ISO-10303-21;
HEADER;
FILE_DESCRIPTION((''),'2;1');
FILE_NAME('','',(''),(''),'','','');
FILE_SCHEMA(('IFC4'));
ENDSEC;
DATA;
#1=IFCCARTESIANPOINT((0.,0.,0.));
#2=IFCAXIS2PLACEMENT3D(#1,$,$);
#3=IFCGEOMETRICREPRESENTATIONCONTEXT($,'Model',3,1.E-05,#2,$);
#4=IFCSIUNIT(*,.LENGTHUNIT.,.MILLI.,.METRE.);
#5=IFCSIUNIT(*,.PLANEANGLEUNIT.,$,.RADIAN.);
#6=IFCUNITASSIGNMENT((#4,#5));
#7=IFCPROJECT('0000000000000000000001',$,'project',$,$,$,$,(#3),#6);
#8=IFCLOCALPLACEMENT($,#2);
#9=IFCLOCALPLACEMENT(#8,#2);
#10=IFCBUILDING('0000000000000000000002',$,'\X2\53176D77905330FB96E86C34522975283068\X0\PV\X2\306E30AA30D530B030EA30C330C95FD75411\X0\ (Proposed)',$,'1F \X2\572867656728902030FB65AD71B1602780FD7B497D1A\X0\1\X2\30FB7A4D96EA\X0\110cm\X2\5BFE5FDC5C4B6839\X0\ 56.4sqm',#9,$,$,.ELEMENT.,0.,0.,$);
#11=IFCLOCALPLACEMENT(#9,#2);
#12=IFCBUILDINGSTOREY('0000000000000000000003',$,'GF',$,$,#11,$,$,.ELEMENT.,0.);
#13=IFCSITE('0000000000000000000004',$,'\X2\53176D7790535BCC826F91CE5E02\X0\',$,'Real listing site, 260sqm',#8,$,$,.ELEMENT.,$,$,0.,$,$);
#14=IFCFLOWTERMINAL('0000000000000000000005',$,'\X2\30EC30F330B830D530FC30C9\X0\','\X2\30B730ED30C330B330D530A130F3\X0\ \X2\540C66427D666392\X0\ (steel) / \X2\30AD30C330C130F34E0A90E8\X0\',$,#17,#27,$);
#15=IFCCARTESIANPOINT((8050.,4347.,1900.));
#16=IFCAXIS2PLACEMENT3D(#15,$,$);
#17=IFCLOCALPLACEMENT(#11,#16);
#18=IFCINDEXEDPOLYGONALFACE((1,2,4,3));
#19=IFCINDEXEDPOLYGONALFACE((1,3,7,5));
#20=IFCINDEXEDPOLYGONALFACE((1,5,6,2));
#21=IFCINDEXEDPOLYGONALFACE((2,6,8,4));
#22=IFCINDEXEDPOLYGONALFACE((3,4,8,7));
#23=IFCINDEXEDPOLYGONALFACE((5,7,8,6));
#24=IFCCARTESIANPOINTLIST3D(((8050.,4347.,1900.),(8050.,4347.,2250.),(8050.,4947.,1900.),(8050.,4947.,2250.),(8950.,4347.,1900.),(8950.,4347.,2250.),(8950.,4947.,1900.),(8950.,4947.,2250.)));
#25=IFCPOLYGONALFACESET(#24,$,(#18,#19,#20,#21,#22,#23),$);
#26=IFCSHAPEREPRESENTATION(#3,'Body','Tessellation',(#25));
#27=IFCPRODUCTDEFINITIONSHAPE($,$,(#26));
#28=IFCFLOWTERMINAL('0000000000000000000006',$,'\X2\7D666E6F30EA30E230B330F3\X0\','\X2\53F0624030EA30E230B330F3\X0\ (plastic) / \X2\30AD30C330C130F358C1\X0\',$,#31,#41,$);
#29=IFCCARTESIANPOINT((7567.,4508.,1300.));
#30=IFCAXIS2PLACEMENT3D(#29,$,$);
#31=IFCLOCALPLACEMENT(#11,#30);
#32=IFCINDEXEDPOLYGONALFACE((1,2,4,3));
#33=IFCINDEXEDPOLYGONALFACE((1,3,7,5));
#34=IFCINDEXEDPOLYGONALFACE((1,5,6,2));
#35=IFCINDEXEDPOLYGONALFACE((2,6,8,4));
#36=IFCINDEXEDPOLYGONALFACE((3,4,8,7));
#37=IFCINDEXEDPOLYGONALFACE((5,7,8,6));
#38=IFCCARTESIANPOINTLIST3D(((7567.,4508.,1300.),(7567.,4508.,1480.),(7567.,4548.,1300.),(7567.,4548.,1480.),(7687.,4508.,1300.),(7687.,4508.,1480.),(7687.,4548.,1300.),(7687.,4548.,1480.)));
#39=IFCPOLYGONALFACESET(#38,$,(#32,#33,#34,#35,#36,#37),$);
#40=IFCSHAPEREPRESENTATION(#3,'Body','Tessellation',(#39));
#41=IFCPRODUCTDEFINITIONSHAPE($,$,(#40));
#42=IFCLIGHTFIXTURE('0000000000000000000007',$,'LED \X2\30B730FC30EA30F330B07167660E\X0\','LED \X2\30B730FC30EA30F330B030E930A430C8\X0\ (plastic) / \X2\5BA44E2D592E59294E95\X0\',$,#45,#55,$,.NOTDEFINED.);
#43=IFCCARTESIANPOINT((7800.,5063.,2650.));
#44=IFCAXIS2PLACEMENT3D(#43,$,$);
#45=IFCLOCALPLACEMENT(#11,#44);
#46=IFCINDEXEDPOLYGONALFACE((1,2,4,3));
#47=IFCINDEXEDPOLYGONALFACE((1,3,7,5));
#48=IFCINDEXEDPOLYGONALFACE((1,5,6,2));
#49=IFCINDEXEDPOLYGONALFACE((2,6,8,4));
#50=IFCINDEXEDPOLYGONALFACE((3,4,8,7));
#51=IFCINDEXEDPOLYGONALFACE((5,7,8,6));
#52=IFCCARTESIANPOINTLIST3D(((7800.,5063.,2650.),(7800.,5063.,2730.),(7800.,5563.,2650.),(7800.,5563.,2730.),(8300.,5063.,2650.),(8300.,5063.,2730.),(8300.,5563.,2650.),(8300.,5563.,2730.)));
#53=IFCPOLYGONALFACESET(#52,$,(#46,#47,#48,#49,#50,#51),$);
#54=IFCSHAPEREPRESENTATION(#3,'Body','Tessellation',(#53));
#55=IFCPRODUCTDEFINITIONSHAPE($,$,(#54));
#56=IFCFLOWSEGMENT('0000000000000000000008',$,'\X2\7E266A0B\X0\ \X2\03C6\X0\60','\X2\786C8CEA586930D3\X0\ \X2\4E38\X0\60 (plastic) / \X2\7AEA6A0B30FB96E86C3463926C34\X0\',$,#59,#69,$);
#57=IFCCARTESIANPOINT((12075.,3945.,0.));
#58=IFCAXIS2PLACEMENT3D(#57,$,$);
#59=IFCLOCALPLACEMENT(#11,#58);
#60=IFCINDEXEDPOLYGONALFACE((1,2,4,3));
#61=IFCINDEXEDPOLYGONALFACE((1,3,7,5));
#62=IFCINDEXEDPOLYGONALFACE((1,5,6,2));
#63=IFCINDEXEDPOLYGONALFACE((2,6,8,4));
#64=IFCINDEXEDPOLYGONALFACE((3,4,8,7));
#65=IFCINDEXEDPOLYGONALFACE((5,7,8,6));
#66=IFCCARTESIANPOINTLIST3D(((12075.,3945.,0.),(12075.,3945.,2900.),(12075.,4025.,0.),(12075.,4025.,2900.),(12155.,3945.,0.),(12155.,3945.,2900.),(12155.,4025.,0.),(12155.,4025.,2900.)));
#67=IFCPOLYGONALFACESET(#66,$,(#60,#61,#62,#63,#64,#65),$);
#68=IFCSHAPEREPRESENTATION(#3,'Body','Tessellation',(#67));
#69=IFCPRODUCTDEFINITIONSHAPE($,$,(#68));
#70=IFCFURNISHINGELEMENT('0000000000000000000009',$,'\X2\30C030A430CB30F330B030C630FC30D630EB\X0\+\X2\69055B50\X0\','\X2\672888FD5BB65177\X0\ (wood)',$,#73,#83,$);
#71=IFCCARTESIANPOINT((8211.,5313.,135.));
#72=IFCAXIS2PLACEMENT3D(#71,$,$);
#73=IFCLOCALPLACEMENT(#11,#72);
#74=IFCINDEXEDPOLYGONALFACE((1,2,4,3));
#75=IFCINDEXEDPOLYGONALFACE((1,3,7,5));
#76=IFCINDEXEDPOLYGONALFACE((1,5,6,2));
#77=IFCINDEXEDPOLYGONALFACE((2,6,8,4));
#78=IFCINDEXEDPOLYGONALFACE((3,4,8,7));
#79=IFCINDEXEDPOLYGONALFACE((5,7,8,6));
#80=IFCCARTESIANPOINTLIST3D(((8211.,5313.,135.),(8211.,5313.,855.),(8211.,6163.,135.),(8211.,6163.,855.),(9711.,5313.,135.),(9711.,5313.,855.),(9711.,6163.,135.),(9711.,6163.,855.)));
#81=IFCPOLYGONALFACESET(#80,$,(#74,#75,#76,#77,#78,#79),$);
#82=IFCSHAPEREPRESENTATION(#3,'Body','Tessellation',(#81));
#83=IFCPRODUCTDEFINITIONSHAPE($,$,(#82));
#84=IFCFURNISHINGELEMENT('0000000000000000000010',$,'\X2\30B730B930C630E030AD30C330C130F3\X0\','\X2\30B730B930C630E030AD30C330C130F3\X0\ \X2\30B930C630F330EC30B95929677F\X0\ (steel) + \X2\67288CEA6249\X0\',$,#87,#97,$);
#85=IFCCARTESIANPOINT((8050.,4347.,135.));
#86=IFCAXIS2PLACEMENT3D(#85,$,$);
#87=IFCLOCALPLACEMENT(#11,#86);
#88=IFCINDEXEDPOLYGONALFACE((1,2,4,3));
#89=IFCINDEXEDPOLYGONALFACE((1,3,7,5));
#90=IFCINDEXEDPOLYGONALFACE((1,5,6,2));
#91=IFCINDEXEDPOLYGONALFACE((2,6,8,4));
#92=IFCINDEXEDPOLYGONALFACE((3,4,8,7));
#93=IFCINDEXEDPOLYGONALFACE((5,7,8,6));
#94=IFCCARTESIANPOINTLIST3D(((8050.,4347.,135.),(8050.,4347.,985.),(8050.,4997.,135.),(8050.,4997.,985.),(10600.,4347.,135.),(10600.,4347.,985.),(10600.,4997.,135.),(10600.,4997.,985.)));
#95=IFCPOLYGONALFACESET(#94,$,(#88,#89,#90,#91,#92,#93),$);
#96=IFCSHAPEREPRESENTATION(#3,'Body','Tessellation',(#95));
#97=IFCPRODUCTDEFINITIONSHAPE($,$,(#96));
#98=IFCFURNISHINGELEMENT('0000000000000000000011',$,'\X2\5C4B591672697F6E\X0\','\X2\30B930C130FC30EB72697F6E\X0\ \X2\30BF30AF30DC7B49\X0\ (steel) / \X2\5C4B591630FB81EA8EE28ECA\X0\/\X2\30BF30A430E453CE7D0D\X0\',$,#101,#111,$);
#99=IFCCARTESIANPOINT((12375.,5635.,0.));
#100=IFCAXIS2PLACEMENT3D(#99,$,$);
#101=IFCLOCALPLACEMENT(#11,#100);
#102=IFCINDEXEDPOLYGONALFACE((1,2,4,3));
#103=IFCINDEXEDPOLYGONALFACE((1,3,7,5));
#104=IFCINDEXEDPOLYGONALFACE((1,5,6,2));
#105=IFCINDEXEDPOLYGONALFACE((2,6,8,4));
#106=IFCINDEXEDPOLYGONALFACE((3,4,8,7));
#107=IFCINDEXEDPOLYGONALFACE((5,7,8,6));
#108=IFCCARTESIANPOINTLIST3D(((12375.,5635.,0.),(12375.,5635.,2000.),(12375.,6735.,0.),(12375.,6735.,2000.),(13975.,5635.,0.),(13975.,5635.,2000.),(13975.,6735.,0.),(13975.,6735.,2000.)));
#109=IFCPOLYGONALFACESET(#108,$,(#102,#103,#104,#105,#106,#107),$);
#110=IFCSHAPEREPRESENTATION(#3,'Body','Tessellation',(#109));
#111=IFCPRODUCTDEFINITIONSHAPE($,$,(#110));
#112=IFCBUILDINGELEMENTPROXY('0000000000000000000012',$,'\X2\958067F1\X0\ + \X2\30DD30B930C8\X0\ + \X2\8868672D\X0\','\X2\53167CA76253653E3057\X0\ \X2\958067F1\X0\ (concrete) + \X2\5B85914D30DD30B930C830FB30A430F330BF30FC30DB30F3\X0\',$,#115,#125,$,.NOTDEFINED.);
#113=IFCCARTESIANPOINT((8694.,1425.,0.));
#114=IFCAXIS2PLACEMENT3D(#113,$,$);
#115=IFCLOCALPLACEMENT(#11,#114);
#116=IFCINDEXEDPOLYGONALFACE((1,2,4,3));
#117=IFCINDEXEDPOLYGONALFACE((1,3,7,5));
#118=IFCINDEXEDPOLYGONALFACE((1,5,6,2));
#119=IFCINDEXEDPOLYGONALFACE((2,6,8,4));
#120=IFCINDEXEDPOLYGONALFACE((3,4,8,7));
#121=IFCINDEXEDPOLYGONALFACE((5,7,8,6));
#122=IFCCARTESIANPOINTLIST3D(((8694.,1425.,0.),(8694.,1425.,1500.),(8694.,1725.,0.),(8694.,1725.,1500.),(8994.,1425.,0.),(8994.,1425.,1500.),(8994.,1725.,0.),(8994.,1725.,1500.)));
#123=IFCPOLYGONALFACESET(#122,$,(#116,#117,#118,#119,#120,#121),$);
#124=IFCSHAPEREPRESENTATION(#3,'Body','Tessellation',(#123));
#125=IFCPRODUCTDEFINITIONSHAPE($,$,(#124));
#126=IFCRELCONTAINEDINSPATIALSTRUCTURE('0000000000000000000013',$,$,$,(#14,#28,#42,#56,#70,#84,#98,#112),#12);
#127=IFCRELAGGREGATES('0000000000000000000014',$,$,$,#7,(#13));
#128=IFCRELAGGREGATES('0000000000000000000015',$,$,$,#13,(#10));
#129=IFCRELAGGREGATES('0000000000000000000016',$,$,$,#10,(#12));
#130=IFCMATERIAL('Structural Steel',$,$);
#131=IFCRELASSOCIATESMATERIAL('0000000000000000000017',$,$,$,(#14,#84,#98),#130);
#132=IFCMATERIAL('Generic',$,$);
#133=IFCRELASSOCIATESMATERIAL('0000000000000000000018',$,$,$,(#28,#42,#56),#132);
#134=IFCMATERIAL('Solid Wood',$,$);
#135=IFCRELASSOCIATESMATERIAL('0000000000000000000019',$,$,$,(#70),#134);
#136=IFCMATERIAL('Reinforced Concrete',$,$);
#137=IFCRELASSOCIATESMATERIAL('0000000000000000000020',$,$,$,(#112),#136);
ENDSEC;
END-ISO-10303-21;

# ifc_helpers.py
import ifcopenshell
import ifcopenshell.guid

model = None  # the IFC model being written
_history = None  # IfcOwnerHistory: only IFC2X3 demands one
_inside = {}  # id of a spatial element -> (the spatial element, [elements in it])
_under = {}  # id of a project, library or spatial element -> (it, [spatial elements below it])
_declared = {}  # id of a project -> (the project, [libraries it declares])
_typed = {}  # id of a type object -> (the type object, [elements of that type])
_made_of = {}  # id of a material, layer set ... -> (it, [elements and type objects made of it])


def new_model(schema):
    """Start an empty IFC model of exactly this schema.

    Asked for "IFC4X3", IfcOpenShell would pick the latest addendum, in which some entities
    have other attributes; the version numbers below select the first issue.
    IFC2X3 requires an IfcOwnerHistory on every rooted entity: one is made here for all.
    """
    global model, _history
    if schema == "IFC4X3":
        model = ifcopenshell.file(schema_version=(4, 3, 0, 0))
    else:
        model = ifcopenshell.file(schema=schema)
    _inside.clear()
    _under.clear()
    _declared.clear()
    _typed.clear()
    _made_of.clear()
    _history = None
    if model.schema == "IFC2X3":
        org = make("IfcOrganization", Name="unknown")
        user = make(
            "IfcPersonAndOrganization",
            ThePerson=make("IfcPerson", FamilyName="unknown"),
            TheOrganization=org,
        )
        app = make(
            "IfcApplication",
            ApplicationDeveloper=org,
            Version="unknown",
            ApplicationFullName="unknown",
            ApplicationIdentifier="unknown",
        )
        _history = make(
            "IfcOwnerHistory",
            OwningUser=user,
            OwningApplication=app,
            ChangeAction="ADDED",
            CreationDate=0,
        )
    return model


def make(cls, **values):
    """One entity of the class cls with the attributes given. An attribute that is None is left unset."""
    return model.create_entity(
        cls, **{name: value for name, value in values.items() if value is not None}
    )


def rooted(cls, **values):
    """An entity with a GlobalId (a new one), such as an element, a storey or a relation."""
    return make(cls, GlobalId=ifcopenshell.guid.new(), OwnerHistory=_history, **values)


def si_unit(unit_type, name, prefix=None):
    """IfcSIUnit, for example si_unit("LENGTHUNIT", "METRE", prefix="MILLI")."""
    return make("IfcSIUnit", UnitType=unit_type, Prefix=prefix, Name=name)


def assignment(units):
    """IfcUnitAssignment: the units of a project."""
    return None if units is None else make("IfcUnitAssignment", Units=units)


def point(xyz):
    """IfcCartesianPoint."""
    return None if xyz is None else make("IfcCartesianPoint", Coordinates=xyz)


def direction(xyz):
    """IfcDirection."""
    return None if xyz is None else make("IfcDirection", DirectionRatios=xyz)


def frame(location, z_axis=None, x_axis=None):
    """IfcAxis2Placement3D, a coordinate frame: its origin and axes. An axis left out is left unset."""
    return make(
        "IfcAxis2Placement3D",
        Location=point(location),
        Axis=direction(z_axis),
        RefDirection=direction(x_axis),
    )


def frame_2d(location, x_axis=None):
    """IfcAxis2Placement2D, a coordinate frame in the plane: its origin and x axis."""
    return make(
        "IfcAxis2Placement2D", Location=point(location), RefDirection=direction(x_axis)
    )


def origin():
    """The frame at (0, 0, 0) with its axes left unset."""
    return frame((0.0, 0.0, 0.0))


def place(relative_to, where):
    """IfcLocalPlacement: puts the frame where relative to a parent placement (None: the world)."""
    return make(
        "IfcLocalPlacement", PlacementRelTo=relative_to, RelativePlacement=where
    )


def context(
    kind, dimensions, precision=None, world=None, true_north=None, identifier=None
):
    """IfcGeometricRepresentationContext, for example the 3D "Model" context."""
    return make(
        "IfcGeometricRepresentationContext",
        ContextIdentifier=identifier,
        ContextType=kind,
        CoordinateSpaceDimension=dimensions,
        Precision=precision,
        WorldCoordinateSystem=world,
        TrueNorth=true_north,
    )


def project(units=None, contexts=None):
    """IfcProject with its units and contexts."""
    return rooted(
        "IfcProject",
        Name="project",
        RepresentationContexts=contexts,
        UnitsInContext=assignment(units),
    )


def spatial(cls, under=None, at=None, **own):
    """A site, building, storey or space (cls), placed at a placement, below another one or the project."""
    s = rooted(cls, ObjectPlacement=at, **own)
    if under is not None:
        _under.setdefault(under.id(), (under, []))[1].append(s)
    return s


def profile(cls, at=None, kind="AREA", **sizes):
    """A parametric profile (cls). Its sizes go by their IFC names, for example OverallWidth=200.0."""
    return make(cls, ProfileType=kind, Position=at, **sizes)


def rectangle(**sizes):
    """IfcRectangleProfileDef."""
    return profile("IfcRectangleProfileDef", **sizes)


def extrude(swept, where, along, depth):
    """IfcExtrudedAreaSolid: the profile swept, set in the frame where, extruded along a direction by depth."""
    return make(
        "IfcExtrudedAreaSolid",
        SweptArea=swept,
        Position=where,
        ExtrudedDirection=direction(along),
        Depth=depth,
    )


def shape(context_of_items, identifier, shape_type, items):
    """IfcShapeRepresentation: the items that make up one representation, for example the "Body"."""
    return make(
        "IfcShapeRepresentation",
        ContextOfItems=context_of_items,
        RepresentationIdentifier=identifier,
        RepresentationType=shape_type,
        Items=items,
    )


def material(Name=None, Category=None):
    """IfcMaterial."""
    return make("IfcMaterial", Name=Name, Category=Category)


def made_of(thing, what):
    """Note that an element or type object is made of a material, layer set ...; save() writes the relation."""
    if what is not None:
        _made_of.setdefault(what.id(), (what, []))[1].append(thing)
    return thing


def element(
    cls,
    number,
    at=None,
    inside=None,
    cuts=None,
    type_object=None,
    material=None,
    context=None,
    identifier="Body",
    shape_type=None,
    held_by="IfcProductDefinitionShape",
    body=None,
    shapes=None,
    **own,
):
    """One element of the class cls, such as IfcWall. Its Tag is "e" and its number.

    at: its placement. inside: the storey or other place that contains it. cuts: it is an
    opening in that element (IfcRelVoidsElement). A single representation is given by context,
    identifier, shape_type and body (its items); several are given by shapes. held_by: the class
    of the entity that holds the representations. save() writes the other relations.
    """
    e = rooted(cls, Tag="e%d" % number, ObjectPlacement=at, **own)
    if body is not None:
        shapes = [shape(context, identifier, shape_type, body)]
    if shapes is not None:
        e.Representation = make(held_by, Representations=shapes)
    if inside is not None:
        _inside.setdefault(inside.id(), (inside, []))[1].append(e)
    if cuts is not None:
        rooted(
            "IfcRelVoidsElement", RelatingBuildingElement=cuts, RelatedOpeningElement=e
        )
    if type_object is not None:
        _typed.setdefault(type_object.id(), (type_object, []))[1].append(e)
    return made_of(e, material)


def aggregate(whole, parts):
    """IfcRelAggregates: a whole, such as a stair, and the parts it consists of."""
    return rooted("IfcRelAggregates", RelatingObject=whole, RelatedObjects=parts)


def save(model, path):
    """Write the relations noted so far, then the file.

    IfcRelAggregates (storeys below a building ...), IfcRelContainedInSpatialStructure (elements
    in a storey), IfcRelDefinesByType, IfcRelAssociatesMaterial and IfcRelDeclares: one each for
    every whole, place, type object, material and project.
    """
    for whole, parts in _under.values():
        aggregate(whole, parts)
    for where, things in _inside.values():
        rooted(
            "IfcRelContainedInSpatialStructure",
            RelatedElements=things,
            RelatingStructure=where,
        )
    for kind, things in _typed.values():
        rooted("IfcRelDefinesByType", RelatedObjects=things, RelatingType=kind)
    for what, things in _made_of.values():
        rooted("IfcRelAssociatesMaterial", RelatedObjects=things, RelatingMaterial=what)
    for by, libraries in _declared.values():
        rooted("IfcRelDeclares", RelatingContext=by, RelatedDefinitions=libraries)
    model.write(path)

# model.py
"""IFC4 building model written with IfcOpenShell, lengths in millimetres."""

from ifc_helpers import new_model, si_unit, frame, frame_2d, origin, place, context, project, spatial, rectangle, extrude, material, element, save


model = new_model("IFC4")

# Units and contexts
model_context = context("Model", 3, precision=1e-05, world=origin())
ifc_project = project(units=[si_unit("LENGTHUNIT", "METRE", prefix="MILLI"), si_unit("PLANEANGLEUNIT", "RADIAN")], contexts=[model_context])

# Site, building, storey
site_placement = place(None, origin())
site = spatial("IfcSite", under=ifc_project, at=site_placement, Name="北海道富良野市", ObjectType="Real listing site, 260sqm", CompositionType="ELEMENT", RefElevation=0.0)
building_placement = place(site_placement, origin())
building = spatial("IfcBuilding", under=site, at=building_placement, Name="北海道・雨水利用とPVのオフグリッド志向 (Proposed)", ObjectType="1F 在来木造・断熱性能等級1・積雪110cm対応屋根 56.4sqm", CompositionType="ELEMENT", ElevationOfRefHeight=0.0, ElevationOfTerrain=0.0)
storey_placement = place(building_placement, origin())
storey = spatial("IfcBuildingStorey", under=building, at=storey_placement, Name="GF", CompositionType="ELEMENT", Elevation=0.0)

# Shared definitions
ifc_material_1 = material(Name="Solid Wood")

# Shared definitions
ifc_material_2 = material(Name="Structural Steel")

# Shared definitions
ifc_material_3 = material(Name="Reinforced Concrete")

# Flow terminals
flow_terminal_1_placement = place(storey_placement, frame((8050.0, 4347.0, 1900.0)))
element("IfcFlowTerminal", 1, at=flow_terminal_1_placement, inside=storey, material=ifc_material_2, Name="レンジフード", Description="シロッコファン 同時給排 (steel) / キッチン上部", context=model_context, shape_type="SweptSolid", body=[
    extrude(rectangle(XDim=900.0, YDim=600.0, at=frame_2d((450.0, 300.0))), frame((8050.0, 4347.0, 1900.0)), (0.0, 0.0, 1.0), 350.0),
])
ifc_material_4 = material(Name="Generic")
flow_terminal_2_placement = place(storey_placement, frame((7567.0, 4508.0, 1300.0)))
element("IfcFlowTerminal", 2, at=flow_terminal_2_placement, inside=storey, material=ifc_material_4, Name="給湯リモコン", Description="台所リモコン (plastic) / キッチン壁", context=model_context, shape_type="SweptSolid", body=[
    extrude(rectangle(XDim=120.0, YDim=40.0, at=frame_2d((60.0, 20.0))), frame((7567.0, 4508.0, 1300.0)), (0.0, 0.0, 1.0), 180.0),
])

# Light fixture
light_fixture_placement = place(storey_placement, frame((7800.0, 5063.0, 2650.0)))
element("IfcLightFixture", 3, at=light_fixture_placement, inside=storey, material=ifc_material_4, Name="LED シーリング照明", Description="LED シーリングライト (plastic) / 室中央天井", PredefinedType="NOTDEFINED", context=model_context, shape_type="SweptSolid", body=[
    extrude(rectangle(XDim=500.0, YDim=500.0, at=frame_2d((250.0, 250.0))), frame((7800.0, 5063.0, 2650.0)), (0.0, 0.0, 1.0), 80.0),
])

# Flow segment
flow_segment_placement = place(storey_placement, frame((12075.0, 3945.0, 0.0)))
element("IfcFlowSegment", 4, at=flow_segment_placement, inside=storey, material=ifc_material_4, Name="縦樋 φ60", Description="硬質塩ビ 丸60 (plastic) / 竪樋・雨水排水", context=model_context, shape_type="SweptSolid", body=[
    extrude(rectangle(XDim=80.0, YDim=80.0, at=frame_2d((40.0, 40.0))), frame((12075.0, 3945.0, 0.0)), (0.0, 0.0, 1.0), 2900.0),
])

# Furnishing elements
furnishing_1_placement = place(storey_placement, frame((8211.0, 5313.0, 135.0)))
element("IfcFurnishingElement", 5, at=furnishing_1_placement, inside=storey, material=ifc_material_1, Name="ダイニングテーブル+椅子", Description="木製家具 (wood)", context=model_context, shape_type="SweptSolid", body=[
    extrude(rectangle(XDim=1500.0, YDim=850.0, at=frame_2d((750.0, 425.0))), frame((8211.0, 5313.0, 135.0)), (0.0, 0.0, 1.0), 720.0),
])
furnishing_2_placement = place(storey_placement, frame((8050.0, 4347.0, 135.0)))
element("IfcFurnishingElement", 6, at=furnishing_2_placement, inside=storey, material=ifc_material_2, Name="システムキッチン", Description="システムキッチン ステンレス天板 (steel) + 木質扉", context=model_context, shape_type="SweptSolid", body=[
    extrude(rectangle(XDim=2550.0, YDim=650.0, at=frame_2d((1275.0, 325.0))), frame((8050.0, 4347.0, 135.0)), (0.0, 0.0, 1.0), 850.0),
])
furnishing_3_placement = place(storey_placement, frame((12375.0, 5635.0, 0.0)))
element("IfcFurnishingElement", 7, at=furnishing_3_placement, inside=storey, material=ifc_material_2, Name="屋外物置", Description="スチール物置 タクボ等 (steel) / 屋外・自転車/タイヤ収納", context=model_context, shape_type="SweptSolid", body=[
    extrude(rectangle(XDim=1600.0, YDim=1100.0, at=frame_2d((800.0, 550.0))), frame((12375.0, 5635.0, 0.0)), (0.0, 0.0, 1.0), 2000.0),
])

# Building element proxy
proxy_placement = place(storey_placement, frame((8694.0, 1425.0, 0.0)))
element("IfcBuildingElementProxy", 8, at=proxy_placement, inside=storey, material=ifc_material_3, Name="門柱 + ポスト + 表札", Description="化粧打放し 門柱 (concrete) + 宅配ポスト・インターホン", PredefinedType="NOTDEFINED", context=model_context, shape_type="SweptSolid", body=[
    extrude(rectangle(XDim=300.0, YDim=300.0, at=frame_2d((150.0, 150.0))), frame((8694.0, 1425.0, 0.0)), (0.0, 0.0, 1.0), 1500.0),
])

save(model, "model.ifc")
